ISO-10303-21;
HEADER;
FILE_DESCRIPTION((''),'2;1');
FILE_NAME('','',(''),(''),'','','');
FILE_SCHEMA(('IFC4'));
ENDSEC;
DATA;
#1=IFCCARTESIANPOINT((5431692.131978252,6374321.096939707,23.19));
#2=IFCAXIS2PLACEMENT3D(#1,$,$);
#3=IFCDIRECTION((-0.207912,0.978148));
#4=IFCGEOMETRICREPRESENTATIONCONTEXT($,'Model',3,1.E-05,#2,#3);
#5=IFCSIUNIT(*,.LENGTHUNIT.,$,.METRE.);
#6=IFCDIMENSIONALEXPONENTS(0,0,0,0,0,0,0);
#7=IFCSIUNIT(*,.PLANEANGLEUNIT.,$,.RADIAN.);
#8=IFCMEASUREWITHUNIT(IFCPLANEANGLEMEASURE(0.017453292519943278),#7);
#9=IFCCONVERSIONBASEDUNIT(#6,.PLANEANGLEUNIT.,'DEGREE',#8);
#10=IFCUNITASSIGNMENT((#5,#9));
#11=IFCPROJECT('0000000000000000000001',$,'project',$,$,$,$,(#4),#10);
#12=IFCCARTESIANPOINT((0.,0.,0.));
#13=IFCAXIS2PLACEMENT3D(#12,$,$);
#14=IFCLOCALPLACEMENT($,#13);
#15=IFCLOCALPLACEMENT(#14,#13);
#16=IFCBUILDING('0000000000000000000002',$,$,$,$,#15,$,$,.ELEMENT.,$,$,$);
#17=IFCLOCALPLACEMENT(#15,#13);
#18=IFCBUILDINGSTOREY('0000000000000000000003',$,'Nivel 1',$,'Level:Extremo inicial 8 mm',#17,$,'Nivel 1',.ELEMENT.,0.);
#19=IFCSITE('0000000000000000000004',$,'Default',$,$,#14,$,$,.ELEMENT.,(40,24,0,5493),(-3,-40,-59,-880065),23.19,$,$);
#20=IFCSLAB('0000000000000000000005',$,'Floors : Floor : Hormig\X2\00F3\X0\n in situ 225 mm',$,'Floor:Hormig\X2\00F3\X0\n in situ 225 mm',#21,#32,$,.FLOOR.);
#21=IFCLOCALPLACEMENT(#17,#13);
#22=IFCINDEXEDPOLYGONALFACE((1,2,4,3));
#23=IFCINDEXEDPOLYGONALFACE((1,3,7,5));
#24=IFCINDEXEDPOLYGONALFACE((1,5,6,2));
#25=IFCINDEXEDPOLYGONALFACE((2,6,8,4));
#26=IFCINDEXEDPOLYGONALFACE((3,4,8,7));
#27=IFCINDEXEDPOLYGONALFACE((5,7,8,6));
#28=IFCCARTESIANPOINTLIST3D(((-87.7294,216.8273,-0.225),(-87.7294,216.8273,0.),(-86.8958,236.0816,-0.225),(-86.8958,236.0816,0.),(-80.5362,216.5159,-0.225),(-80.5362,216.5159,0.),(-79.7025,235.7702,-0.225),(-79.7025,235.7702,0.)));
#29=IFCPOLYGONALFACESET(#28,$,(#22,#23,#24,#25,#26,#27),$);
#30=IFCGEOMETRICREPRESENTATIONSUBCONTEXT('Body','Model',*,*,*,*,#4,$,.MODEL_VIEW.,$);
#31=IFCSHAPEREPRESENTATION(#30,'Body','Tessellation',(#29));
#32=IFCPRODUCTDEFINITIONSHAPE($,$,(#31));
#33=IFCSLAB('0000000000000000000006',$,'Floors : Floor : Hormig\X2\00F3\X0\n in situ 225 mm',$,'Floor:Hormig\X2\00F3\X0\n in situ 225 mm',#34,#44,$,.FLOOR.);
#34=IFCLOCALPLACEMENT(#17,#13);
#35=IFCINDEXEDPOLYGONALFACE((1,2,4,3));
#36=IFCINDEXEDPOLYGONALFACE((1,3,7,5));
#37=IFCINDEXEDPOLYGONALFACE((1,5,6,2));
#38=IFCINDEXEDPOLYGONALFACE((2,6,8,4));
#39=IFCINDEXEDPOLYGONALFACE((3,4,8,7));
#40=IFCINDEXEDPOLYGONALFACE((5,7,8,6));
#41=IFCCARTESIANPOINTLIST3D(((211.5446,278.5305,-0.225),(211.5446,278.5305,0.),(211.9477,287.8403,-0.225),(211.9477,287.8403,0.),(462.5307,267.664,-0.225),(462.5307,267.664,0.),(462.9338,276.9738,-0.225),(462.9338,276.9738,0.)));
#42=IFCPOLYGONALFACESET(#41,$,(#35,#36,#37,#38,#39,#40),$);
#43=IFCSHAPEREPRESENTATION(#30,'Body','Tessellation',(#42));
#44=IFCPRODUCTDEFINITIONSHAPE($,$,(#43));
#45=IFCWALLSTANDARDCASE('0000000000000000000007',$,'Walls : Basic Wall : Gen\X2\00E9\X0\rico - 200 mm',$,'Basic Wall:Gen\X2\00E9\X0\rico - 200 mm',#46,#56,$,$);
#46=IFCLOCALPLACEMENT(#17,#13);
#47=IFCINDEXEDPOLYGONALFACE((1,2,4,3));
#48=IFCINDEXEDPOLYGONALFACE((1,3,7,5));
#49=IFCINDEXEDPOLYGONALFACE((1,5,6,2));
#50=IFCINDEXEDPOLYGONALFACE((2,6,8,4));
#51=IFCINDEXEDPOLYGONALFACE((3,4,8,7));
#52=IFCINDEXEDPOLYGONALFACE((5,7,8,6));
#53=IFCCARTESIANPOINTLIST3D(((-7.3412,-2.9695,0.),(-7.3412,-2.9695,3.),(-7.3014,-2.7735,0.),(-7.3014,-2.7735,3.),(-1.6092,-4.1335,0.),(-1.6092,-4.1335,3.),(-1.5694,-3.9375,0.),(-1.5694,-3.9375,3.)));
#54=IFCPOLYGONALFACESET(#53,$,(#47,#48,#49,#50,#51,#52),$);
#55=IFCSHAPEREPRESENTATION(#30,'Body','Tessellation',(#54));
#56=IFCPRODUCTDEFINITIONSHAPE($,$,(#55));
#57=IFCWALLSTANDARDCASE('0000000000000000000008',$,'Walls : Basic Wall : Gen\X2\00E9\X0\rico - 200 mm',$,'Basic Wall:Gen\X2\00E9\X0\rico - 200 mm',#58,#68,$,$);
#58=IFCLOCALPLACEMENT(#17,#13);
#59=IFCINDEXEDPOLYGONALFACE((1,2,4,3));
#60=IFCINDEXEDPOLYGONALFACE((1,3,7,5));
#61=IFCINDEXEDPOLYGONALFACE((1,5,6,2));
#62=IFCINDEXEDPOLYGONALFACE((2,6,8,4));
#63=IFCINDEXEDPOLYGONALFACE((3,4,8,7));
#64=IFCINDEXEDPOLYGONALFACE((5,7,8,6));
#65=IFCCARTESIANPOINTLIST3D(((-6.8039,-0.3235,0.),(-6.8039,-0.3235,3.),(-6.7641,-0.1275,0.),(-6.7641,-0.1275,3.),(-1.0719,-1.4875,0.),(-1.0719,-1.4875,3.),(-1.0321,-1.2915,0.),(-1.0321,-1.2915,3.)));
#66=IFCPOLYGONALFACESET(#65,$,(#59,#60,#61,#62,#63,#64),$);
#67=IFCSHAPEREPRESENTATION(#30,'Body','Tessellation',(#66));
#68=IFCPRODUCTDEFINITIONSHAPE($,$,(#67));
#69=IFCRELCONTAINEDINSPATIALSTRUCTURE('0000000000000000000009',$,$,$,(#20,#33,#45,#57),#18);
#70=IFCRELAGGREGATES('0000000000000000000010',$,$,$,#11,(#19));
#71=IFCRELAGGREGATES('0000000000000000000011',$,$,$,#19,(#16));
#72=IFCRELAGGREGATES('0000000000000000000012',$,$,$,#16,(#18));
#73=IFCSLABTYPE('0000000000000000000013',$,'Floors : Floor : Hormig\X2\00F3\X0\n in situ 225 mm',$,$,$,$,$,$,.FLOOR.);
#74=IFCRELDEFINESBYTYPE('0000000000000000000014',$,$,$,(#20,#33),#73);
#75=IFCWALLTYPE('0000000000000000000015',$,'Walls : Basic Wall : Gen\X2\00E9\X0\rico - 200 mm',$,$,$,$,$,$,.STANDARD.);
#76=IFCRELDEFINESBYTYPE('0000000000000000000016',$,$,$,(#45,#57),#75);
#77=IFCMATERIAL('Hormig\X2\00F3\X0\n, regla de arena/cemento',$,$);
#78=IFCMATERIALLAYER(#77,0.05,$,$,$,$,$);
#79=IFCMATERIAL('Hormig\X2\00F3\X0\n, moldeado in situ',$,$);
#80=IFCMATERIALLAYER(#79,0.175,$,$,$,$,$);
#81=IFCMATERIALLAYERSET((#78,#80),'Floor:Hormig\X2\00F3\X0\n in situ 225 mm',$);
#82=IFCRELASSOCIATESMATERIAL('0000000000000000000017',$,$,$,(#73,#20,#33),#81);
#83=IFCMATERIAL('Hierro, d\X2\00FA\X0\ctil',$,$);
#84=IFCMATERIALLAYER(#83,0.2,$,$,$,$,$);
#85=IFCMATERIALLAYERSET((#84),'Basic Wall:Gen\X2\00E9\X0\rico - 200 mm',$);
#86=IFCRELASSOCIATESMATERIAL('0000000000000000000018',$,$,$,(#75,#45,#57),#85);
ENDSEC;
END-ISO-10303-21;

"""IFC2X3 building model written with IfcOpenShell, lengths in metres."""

from ifc_helpers import new_model, entity, si_unit, converted_unit, direction, frame, frame_2d, origin, place, context, subcontext, project, spatial, rectangle, extrude, material, layer, layer_set, layer_usage, type_object, element, save


model = new_model("IFC2X3")

# Units and contexts
model_context = context("Model", 3, precision=1e-05, world=frame((5431692.131978252, 6374321.096939707, 23.19)), true_north=direction((-0.207912, 0.978148)))
body_context = subcontext(model_context, "Body", "Model", "MODEL_VIEW")
ifc_project = project(units=[si_unit("LENGTHUNIT", "METRE"), converted_unit("PLANEANGLEUNIT", "DEGREE", entity("IfcPlaneAngleMeasure", 0.017453292519943278), si_unit("PLANEANGLEUNIT", "RADIAN"), dimensions=[0, 0, 0, 0, 0, 0, 0])], contexts=[model_context])

# Site, building, storey
site_placement = place(None, origin())
site = spatial("IfcSite", under=ifc_project, at=site_placement, Name="Default", CompositionType="ELEMENT", RefLatitude=(40, 24, 0, 5493), RefLongitude=(-3, -40, -59, -880065), RefElevation=23.19)
building_placement = place(site_placement, origin())
building = spatial("IfcBuilding", under=site, at=building_placement, CompositionType="ELEMENT")
storey_placement = place(building_placement, origin())
storey = spatial("IfcBuildingStorey", under=building, at=storey_placement, Name="Nivel 1", ObjectType="Level:Extremo inicial 8 mm", LongName="Nivel 1", CompositionType="ELEMENT", Elevation=0.0)

# Slabs
ifc_material_1 = material(Name="Hormigón, regla de arena/cemento")
ifc_layer_1 = layer(ifc_material_1, 0.05)
ifc_material_2 = material(Name="Hormigón, moldeado in situ")
ifc_layer_2 = layer(ifc_material_2, 0.175)
ifc_layer_set_1 = layer_set([ifc_layer_1, ifc_layer_2], Name="Floor:Hormigón in situ 225 mm")
ifc_layer_usage_1 = layer_usage(ifc_layer_set_1, "AXIS3", "POSITIVE", 0.0)
slab_type = type_object("IfcSlabType", Name="Floors : Floor : Hormigón in situ 225 mm", PredefinedType="FLOOR", material=ifc_layer_set_1)
slab_1_placement = place(storey_placement, origin())
element("IfcSlab", 1, at=slab_1_placement, inside=storey, type_object=slab_type, material=ifc_layer_usage_1, Name="Floors : Floor : Hormigón in situ 225 mm", ObjectType="Floor:Hormigón in situ 225 mm", PredefinedType="FLOOR", context=body_context, shape_type="SweptSolid", body=[
    extrude(rectangle(XDim=19.2724, YDim=7.2, at=frame_2d((0.0, 0.0), x_axis=(1.0, 0.0))), frame((-83.716, 226.2988, 0.0), z_axis=(0.0, 0.0, -1.0), x_axis=(-0.043255, -0.999064, 0.0)), (0.0, 0.0, 1.0), 0.225),
])
ifc_layer_usage_2 = layer_usage(ifc_layer_set_1, "AXIS3", "POSITIVE", 0.0)
slab_2_placement = place(storey_placement, origin())
element("IfcSlab", 2, at=slab_2_placement, inside=storey, type_object=slab_type, material=ifc_layer_usage_2, Name="Floors : Floor : Hormigón in situ 225 mm", ObjectType="Floor:Hormigón in situ 225 mm", PredefinedType="FLOOR", context=body_context, shape_type="SweptSolid", body=[
    extrude(rectangle(XDim=251.2212, YDim=9.3185, at=frame_2d((0.0, 0.0), x_axis=(1.0, 0.0))), frame((337.2392, 277.7522, 0.0), z_axis=(0.0, 0.0, -1.0), x_axis=(0.999064, -0.043255, 0.0)), (0.0, 0.0, 1.0), 0.225),
])

# Walls
ifc_material_3 = material(Name="Hierro, dúctil")
ifc_layer_3 = layer(ifc_material_3, 0.2)
ifc_layer_set_2 = layer_set([ifc_layer_3], Name="Basic Wall:Genérico - 200 mm")
ifc_layer_usage_3 = layer_usage(ifc_layer_set_2, "AXIS2", "NEGATIVE", 0.1)
wall_type = type_object("IfcWallType", Name="Walls : Basic Wall : Genérico - 200 mm", PredefinedType="STANDARD", material=ifc_layer_set_2)
wall_1_placement = place(storey_placement, frame((-1.5893, -4.0355, 0.0), z_axis=(0.0, 0.0, 1.0), x_axis=(-0.979997, 0.19901, 0.0)))
element("IfcWallStandardCase", 3, at=wall_1_placement, inside=storey, type_object=wall_type, material=ifc_layer_usage_3, Name="Walls : Basic Wall : Genérico - 200 mm", ObjectType="Basic Wall:Genérico - 200 mm", context=body_context, shape_type="SweptSolid", body=[
    extrude(rectangle(XDim=5.849, YDim=0.2, at=frame_2d((2.9245, 0.0), x_axis=(-1.0, 0.0))), origin(), (0.0, 0.0, 1.0), 3.0),
])
ifc_layer_usage_4 = layer_usage(ifc_layer_set_2, "AXIS2", "NEGATIVE", 0.1)
wall_2_placement = place(storey_placement, frame((-1.052, -1.3895, 0.0), z_axis=(0.0, 0.0, 1.0), x_axis=(-0.979997, 0.19901, 0.0)))
element("IfcWallStandardCase", 4, at=wall_2_placement, inside=storey, type_object=wall_type, material=ifc_layer_usage_4, Name="Walls : Basic Wall : Genérico - 200 mm", ObjectType="Basic Wall:Genérico - 200 mm", context=body_context, shape_type="SweptSolid", body=[
    extrude(rectangle(XDim=5.849, YDim=0.2, at=frame_2d((2.9245, 0.0), x_axis=(-1.0, 0.0))), origin(), (0.0, 0.0, 1.0), 3.0),
])

save(model, "model.ifc")
